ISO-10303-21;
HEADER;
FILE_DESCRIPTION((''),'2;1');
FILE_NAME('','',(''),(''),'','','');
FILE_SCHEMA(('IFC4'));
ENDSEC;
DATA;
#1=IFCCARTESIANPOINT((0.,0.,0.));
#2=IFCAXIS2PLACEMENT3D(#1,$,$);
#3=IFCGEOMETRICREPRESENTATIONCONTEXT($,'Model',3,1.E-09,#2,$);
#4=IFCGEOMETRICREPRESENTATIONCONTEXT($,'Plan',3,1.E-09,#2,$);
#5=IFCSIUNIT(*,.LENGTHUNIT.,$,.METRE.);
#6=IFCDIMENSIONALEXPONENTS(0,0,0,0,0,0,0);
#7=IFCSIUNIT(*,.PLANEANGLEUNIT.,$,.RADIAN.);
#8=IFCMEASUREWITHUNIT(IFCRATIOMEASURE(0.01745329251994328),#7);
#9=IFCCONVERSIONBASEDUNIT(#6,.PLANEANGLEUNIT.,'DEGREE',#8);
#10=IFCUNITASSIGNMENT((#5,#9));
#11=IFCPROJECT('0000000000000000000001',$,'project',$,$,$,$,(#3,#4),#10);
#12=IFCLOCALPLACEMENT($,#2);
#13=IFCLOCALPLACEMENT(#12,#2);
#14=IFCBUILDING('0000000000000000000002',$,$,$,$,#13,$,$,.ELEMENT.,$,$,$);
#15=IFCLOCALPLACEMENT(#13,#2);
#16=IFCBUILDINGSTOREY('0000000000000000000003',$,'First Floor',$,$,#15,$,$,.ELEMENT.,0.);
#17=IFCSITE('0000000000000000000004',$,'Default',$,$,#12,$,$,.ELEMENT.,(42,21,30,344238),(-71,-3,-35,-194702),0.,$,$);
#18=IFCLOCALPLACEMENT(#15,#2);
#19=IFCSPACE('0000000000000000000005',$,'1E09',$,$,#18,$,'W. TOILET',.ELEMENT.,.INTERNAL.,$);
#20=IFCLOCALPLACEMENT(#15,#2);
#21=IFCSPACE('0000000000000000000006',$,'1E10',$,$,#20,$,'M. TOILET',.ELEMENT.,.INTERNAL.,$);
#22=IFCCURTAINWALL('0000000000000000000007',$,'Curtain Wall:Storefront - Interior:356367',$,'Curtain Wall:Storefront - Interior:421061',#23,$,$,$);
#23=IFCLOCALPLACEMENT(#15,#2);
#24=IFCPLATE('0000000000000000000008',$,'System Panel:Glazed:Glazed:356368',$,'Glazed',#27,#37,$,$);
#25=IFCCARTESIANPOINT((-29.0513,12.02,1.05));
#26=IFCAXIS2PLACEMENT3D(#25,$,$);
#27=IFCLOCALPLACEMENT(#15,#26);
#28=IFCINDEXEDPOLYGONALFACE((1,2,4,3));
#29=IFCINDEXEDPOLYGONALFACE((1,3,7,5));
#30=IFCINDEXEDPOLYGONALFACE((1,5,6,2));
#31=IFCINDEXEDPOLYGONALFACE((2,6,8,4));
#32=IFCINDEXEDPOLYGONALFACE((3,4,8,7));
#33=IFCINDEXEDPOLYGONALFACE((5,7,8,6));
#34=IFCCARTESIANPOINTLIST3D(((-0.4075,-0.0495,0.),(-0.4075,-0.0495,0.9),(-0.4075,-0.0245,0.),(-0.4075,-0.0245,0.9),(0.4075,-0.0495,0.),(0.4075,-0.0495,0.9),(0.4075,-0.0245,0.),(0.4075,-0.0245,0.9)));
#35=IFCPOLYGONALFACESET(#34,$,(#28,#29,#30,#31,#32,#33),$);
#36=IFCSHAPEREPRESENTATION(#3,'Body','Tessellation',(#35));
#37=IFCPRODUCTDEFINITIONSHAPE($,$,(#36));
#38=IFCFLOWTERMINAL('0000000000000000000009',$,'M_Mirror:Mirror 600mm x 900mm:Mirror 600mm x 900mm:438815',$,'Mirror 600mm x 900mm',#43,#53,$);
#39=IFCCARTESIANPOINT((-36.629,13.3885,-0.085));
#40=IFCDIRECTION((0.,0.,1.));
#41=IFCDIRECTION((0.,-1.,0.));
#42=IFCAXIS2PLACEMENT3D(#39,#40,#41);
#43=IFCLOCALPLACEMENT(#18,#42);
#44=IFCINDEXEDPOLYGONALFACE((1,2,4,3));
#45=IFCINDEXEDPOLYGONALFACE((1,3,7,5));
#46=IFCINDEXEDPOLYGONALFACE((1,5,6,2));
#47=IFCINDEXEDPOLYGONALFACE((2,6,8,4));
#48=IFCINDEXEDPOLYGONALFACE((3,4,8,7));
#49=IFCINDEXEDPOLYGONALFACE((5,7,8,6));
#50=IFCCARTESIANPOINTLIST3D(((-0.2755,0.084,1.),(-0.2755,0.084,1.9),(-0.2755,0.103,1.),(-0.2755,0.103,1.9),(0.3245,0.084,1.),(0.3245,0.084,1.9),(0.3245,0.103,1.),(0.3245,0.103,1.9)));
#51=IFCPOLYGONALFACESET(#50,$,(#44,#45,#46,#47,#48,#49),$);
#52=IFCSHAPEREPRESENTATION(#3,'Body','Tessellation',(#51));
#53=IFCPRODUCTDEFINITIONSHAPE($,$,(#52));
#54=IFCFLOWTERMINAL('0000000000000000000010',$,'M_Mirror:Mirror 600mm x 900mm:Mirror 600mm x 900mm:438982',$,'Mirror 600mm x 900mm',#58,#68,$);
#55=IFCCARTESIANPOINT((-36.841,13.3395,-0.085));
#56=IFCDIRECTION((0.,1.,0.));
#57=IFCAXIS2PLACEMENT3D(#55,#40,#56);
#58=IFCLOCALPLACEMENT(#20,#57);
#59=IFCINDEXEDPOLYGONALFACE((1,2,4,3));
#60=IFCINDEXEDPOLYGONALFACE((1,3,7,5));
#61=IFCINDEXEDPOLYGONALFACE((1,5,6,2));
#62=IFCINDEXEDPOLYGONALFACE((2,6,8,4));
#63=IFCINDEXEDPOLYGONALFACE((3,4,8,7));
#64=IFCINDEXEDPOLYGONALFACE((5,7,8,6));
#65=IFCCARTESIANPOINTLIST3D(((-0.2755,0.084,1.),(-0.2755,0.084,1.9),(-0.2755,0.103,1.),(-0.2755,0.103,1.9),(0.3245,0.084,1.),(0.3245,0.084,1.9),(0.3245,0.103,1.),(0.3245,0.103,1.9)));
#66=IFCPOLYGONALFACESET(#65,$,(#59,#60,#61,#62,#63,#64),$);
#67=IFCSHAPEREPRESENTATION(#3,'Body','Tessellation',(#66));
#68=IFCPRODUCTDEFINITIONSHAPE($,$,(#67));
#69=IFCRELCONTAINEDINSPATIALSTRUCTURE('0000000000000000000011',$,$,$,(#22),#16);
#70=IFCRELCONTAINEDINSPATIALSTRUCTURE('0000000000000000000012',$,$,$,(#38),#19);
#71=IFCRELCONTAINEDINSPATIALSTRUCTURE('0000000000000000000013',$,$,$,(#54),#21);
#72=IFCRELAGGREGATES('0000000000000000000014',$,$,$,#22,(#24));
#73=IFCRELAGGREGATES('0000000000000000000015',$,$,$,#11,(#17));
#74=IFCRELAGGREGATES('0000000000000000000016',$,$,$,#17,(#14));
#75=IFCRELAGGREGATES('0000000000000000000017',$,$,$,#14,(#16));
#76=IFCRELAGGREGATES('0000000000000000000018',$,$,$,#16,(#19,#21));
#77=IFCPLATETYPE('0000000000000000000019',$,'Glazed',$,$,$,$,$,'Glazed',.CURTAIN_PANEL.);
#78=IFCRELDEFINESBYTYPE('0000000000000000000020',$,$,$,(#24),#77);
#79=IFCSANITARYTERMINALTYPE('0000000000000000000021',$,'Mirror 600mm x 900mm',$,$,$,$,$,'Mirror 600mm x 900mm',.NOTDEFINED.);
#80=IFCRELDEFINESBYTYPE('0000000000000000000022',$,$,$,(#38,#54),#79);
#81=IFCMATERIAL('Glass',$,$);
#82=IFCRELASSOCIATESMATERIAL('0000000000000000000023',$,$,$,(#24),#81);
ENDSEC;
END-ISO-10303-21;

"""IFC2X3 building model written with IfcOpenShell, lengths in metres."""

from ifc_helpers import new_model, entity, si_unit, converted_unit, frame, origin, origin_2d_with_axis, place, context, project, spatial, rectangle, extrude, source, transform, mapped, material, type_object, type_shapes, element, aggregate, save


model = new_model("IFC2X3")

# Units and contexts
model_context = context("Model", 3, precision=1e-09, world=origin())
plan_context = context("Plan", 3, precision=1e-09, world=origin())
ifc_project = project(units=[si_unit("LENGTHUNIT", "METRE"), converted_unit("PLANEANGLEUNIT", "DEGREE", entity("IfcRatioMeasure", 0.01745329251994328), si_unit("PLANEANGLEUNIT", "RADIAN"), dimensions=[0, 0, 0, 0, 0, 0, 0])], contexts=[model_context, plan_context])

# Site, building, storey
site_placement = place(None, origin())
site = spatial("IfcSite", under=ifc_project, at=site_placement, Name="Default", CompositionType="ELEMENT", RefLatitude=(42, 21, 30, 344238), RefLongitude=(-71, -3, -35, -194702), RefElevation=0.0)
building_placement = place(site_placement, origin())
building = spatial("IfcBuilding", under=site, at=building_placement, CompositionType="ELEMENT")
storey_placement = place(building_placement, origin())
storey = spatial("IfcBuildingStorey", under=building, at=storey_placement, Name="First Floor", CompositionType="ELEMENT", Elevation=0.0)

# Curtain wall, plate
curtain_wall_placement = place(storey_placement, origin())
curtain_wall = element("IfcCurtainWall", 1, at=curtain_wall_placement, inside=storey, Name="Curtain Wall:Storefront - Interior:356367", ObjectType="Curtain Wall:Storefront - Interior:421061")
ifc_material_1 = material(Name="Glass")
plate_type = type_object("IfcPlateType", Name="Glazed", ElementType="Glazed", PredefinedType="CURTAIN_PANEL")
shared_shape_1 = source(origin(), model_context, "Body", "SweptSolid", [
    extrude(rectangle(XDim=0.025, YDim=0.815, at=origin_2d_with_axis()), frame((0.0, -0.037, 0.0), z_axis=(0.0, 0.0, 1.0), x_axis=(0.0, 1.0, 0.0)), (0.0, 0.0, 1.0), 0.9),
])
type_shapes(plate_type, [shared_shape_1])
plate_placement = place(storey_placement, frame((-29.0513, 12.02, 1.05)))
plate = element("IfcPlate", 2, at=plate_placement, type_object=plate_type, material=ifc_material_1, Name="System Panel:Glazed:Glazed:356368", ObjectType="Glazed", context=model_context, shape_type="MappedRepresentation", body=[
    mapped(shared_shape_1, transform((0.0, 0.0, 0.0), scale=1.0)),
])
aggregate(curtain_wall, [plate])

# Shared definitions
space_1_placement = place(storey_placement, origin())
space_1 = spatial("IfcSpace", under=storey, at=space_1_placement, Name="1E09", LongName="W. TOILET", CompositionType="ELEMENT", InteriorOrExteriorSpace="INTERNAL")

# Flow terminal
sanitary_terminal_type = type_object("IfcSanitaryTerminalType", Name="Mirror 600mm x 900mm", ElementType="Mirror 600mm x 900mm", PredefinedType="NOTDEFINED")
shared_shape_2 = source(origin(), model_context, "Body", "SweptSolid", [
    extrude(rectangle(XDim=0.0191, YDim=0.6, at=origin_2d_with_axis()), frame((0.0245, 0.0935, 1.0), z_axis=(0.0, 0.0, 1.0), x_axis=(0.0, -1.0, 0.0)), (0.0, 0.0, 1.0), 0.9),
])
type_shapes(sanitary_terminal_type, [shared_shape_2])
flow_terminal_1_placement = place(space_1_placement, frame((-36.629, 13.3885, -0.085), z_axis=(0.0, 0.0, 1.0), x_axis=(0.0, -1.0, 0.0)))
element("IfcFlowTerminal", 3, at=flow_terminal_1_placement, inside=space_1, type_object=sanitary_terminal_type, Name="M_Mirror:Mirror 600mm x 900mm:Mirror 600mm x 900mm:438815", ObjectType="Mirror 600mm x 900mm", context=model_context, shape_type="MappedRepresentation", body=[
    mapped(shared_shape_2, transform((0.0, 0.0, 0.0), scale=1.0)),
])

# Shared definitions
space_2_placement = place(storey_placement, origin())
space_2 = spatial("IfcSpace", under=storey, at=space_2_placement, Name="1E10", LongName="M. TOILET", CompositionType="ELEMENT", InteriorOrExteriorSpace="INTERNAL")

# Flow terminal
flow_terminal_2_placement = place(space_2_placement, frame((-36.841, 13.3395, -0.085), z_axis=(0.0, 0.0, 1.0), x_axis=(0.0, 1.0, 0.0)))
element("IfcFlowTerminal", 4, at=flow_terminal_2_placement, inside=space_2, type_object=sanitary_terminal_type, Name="M_Mirror:Mirror 600mm x 900mm:Mirror 600mm x 900mm:438982", ObjectType="Mirror 600mm x 900mm", context=model_context, shape_type="MappedRepresentation", body=[
    mapped(shared_shape_2, transform((0.0, 0.0, 0.0), scale=1.0)),
])

save(model, "model.ifc")
